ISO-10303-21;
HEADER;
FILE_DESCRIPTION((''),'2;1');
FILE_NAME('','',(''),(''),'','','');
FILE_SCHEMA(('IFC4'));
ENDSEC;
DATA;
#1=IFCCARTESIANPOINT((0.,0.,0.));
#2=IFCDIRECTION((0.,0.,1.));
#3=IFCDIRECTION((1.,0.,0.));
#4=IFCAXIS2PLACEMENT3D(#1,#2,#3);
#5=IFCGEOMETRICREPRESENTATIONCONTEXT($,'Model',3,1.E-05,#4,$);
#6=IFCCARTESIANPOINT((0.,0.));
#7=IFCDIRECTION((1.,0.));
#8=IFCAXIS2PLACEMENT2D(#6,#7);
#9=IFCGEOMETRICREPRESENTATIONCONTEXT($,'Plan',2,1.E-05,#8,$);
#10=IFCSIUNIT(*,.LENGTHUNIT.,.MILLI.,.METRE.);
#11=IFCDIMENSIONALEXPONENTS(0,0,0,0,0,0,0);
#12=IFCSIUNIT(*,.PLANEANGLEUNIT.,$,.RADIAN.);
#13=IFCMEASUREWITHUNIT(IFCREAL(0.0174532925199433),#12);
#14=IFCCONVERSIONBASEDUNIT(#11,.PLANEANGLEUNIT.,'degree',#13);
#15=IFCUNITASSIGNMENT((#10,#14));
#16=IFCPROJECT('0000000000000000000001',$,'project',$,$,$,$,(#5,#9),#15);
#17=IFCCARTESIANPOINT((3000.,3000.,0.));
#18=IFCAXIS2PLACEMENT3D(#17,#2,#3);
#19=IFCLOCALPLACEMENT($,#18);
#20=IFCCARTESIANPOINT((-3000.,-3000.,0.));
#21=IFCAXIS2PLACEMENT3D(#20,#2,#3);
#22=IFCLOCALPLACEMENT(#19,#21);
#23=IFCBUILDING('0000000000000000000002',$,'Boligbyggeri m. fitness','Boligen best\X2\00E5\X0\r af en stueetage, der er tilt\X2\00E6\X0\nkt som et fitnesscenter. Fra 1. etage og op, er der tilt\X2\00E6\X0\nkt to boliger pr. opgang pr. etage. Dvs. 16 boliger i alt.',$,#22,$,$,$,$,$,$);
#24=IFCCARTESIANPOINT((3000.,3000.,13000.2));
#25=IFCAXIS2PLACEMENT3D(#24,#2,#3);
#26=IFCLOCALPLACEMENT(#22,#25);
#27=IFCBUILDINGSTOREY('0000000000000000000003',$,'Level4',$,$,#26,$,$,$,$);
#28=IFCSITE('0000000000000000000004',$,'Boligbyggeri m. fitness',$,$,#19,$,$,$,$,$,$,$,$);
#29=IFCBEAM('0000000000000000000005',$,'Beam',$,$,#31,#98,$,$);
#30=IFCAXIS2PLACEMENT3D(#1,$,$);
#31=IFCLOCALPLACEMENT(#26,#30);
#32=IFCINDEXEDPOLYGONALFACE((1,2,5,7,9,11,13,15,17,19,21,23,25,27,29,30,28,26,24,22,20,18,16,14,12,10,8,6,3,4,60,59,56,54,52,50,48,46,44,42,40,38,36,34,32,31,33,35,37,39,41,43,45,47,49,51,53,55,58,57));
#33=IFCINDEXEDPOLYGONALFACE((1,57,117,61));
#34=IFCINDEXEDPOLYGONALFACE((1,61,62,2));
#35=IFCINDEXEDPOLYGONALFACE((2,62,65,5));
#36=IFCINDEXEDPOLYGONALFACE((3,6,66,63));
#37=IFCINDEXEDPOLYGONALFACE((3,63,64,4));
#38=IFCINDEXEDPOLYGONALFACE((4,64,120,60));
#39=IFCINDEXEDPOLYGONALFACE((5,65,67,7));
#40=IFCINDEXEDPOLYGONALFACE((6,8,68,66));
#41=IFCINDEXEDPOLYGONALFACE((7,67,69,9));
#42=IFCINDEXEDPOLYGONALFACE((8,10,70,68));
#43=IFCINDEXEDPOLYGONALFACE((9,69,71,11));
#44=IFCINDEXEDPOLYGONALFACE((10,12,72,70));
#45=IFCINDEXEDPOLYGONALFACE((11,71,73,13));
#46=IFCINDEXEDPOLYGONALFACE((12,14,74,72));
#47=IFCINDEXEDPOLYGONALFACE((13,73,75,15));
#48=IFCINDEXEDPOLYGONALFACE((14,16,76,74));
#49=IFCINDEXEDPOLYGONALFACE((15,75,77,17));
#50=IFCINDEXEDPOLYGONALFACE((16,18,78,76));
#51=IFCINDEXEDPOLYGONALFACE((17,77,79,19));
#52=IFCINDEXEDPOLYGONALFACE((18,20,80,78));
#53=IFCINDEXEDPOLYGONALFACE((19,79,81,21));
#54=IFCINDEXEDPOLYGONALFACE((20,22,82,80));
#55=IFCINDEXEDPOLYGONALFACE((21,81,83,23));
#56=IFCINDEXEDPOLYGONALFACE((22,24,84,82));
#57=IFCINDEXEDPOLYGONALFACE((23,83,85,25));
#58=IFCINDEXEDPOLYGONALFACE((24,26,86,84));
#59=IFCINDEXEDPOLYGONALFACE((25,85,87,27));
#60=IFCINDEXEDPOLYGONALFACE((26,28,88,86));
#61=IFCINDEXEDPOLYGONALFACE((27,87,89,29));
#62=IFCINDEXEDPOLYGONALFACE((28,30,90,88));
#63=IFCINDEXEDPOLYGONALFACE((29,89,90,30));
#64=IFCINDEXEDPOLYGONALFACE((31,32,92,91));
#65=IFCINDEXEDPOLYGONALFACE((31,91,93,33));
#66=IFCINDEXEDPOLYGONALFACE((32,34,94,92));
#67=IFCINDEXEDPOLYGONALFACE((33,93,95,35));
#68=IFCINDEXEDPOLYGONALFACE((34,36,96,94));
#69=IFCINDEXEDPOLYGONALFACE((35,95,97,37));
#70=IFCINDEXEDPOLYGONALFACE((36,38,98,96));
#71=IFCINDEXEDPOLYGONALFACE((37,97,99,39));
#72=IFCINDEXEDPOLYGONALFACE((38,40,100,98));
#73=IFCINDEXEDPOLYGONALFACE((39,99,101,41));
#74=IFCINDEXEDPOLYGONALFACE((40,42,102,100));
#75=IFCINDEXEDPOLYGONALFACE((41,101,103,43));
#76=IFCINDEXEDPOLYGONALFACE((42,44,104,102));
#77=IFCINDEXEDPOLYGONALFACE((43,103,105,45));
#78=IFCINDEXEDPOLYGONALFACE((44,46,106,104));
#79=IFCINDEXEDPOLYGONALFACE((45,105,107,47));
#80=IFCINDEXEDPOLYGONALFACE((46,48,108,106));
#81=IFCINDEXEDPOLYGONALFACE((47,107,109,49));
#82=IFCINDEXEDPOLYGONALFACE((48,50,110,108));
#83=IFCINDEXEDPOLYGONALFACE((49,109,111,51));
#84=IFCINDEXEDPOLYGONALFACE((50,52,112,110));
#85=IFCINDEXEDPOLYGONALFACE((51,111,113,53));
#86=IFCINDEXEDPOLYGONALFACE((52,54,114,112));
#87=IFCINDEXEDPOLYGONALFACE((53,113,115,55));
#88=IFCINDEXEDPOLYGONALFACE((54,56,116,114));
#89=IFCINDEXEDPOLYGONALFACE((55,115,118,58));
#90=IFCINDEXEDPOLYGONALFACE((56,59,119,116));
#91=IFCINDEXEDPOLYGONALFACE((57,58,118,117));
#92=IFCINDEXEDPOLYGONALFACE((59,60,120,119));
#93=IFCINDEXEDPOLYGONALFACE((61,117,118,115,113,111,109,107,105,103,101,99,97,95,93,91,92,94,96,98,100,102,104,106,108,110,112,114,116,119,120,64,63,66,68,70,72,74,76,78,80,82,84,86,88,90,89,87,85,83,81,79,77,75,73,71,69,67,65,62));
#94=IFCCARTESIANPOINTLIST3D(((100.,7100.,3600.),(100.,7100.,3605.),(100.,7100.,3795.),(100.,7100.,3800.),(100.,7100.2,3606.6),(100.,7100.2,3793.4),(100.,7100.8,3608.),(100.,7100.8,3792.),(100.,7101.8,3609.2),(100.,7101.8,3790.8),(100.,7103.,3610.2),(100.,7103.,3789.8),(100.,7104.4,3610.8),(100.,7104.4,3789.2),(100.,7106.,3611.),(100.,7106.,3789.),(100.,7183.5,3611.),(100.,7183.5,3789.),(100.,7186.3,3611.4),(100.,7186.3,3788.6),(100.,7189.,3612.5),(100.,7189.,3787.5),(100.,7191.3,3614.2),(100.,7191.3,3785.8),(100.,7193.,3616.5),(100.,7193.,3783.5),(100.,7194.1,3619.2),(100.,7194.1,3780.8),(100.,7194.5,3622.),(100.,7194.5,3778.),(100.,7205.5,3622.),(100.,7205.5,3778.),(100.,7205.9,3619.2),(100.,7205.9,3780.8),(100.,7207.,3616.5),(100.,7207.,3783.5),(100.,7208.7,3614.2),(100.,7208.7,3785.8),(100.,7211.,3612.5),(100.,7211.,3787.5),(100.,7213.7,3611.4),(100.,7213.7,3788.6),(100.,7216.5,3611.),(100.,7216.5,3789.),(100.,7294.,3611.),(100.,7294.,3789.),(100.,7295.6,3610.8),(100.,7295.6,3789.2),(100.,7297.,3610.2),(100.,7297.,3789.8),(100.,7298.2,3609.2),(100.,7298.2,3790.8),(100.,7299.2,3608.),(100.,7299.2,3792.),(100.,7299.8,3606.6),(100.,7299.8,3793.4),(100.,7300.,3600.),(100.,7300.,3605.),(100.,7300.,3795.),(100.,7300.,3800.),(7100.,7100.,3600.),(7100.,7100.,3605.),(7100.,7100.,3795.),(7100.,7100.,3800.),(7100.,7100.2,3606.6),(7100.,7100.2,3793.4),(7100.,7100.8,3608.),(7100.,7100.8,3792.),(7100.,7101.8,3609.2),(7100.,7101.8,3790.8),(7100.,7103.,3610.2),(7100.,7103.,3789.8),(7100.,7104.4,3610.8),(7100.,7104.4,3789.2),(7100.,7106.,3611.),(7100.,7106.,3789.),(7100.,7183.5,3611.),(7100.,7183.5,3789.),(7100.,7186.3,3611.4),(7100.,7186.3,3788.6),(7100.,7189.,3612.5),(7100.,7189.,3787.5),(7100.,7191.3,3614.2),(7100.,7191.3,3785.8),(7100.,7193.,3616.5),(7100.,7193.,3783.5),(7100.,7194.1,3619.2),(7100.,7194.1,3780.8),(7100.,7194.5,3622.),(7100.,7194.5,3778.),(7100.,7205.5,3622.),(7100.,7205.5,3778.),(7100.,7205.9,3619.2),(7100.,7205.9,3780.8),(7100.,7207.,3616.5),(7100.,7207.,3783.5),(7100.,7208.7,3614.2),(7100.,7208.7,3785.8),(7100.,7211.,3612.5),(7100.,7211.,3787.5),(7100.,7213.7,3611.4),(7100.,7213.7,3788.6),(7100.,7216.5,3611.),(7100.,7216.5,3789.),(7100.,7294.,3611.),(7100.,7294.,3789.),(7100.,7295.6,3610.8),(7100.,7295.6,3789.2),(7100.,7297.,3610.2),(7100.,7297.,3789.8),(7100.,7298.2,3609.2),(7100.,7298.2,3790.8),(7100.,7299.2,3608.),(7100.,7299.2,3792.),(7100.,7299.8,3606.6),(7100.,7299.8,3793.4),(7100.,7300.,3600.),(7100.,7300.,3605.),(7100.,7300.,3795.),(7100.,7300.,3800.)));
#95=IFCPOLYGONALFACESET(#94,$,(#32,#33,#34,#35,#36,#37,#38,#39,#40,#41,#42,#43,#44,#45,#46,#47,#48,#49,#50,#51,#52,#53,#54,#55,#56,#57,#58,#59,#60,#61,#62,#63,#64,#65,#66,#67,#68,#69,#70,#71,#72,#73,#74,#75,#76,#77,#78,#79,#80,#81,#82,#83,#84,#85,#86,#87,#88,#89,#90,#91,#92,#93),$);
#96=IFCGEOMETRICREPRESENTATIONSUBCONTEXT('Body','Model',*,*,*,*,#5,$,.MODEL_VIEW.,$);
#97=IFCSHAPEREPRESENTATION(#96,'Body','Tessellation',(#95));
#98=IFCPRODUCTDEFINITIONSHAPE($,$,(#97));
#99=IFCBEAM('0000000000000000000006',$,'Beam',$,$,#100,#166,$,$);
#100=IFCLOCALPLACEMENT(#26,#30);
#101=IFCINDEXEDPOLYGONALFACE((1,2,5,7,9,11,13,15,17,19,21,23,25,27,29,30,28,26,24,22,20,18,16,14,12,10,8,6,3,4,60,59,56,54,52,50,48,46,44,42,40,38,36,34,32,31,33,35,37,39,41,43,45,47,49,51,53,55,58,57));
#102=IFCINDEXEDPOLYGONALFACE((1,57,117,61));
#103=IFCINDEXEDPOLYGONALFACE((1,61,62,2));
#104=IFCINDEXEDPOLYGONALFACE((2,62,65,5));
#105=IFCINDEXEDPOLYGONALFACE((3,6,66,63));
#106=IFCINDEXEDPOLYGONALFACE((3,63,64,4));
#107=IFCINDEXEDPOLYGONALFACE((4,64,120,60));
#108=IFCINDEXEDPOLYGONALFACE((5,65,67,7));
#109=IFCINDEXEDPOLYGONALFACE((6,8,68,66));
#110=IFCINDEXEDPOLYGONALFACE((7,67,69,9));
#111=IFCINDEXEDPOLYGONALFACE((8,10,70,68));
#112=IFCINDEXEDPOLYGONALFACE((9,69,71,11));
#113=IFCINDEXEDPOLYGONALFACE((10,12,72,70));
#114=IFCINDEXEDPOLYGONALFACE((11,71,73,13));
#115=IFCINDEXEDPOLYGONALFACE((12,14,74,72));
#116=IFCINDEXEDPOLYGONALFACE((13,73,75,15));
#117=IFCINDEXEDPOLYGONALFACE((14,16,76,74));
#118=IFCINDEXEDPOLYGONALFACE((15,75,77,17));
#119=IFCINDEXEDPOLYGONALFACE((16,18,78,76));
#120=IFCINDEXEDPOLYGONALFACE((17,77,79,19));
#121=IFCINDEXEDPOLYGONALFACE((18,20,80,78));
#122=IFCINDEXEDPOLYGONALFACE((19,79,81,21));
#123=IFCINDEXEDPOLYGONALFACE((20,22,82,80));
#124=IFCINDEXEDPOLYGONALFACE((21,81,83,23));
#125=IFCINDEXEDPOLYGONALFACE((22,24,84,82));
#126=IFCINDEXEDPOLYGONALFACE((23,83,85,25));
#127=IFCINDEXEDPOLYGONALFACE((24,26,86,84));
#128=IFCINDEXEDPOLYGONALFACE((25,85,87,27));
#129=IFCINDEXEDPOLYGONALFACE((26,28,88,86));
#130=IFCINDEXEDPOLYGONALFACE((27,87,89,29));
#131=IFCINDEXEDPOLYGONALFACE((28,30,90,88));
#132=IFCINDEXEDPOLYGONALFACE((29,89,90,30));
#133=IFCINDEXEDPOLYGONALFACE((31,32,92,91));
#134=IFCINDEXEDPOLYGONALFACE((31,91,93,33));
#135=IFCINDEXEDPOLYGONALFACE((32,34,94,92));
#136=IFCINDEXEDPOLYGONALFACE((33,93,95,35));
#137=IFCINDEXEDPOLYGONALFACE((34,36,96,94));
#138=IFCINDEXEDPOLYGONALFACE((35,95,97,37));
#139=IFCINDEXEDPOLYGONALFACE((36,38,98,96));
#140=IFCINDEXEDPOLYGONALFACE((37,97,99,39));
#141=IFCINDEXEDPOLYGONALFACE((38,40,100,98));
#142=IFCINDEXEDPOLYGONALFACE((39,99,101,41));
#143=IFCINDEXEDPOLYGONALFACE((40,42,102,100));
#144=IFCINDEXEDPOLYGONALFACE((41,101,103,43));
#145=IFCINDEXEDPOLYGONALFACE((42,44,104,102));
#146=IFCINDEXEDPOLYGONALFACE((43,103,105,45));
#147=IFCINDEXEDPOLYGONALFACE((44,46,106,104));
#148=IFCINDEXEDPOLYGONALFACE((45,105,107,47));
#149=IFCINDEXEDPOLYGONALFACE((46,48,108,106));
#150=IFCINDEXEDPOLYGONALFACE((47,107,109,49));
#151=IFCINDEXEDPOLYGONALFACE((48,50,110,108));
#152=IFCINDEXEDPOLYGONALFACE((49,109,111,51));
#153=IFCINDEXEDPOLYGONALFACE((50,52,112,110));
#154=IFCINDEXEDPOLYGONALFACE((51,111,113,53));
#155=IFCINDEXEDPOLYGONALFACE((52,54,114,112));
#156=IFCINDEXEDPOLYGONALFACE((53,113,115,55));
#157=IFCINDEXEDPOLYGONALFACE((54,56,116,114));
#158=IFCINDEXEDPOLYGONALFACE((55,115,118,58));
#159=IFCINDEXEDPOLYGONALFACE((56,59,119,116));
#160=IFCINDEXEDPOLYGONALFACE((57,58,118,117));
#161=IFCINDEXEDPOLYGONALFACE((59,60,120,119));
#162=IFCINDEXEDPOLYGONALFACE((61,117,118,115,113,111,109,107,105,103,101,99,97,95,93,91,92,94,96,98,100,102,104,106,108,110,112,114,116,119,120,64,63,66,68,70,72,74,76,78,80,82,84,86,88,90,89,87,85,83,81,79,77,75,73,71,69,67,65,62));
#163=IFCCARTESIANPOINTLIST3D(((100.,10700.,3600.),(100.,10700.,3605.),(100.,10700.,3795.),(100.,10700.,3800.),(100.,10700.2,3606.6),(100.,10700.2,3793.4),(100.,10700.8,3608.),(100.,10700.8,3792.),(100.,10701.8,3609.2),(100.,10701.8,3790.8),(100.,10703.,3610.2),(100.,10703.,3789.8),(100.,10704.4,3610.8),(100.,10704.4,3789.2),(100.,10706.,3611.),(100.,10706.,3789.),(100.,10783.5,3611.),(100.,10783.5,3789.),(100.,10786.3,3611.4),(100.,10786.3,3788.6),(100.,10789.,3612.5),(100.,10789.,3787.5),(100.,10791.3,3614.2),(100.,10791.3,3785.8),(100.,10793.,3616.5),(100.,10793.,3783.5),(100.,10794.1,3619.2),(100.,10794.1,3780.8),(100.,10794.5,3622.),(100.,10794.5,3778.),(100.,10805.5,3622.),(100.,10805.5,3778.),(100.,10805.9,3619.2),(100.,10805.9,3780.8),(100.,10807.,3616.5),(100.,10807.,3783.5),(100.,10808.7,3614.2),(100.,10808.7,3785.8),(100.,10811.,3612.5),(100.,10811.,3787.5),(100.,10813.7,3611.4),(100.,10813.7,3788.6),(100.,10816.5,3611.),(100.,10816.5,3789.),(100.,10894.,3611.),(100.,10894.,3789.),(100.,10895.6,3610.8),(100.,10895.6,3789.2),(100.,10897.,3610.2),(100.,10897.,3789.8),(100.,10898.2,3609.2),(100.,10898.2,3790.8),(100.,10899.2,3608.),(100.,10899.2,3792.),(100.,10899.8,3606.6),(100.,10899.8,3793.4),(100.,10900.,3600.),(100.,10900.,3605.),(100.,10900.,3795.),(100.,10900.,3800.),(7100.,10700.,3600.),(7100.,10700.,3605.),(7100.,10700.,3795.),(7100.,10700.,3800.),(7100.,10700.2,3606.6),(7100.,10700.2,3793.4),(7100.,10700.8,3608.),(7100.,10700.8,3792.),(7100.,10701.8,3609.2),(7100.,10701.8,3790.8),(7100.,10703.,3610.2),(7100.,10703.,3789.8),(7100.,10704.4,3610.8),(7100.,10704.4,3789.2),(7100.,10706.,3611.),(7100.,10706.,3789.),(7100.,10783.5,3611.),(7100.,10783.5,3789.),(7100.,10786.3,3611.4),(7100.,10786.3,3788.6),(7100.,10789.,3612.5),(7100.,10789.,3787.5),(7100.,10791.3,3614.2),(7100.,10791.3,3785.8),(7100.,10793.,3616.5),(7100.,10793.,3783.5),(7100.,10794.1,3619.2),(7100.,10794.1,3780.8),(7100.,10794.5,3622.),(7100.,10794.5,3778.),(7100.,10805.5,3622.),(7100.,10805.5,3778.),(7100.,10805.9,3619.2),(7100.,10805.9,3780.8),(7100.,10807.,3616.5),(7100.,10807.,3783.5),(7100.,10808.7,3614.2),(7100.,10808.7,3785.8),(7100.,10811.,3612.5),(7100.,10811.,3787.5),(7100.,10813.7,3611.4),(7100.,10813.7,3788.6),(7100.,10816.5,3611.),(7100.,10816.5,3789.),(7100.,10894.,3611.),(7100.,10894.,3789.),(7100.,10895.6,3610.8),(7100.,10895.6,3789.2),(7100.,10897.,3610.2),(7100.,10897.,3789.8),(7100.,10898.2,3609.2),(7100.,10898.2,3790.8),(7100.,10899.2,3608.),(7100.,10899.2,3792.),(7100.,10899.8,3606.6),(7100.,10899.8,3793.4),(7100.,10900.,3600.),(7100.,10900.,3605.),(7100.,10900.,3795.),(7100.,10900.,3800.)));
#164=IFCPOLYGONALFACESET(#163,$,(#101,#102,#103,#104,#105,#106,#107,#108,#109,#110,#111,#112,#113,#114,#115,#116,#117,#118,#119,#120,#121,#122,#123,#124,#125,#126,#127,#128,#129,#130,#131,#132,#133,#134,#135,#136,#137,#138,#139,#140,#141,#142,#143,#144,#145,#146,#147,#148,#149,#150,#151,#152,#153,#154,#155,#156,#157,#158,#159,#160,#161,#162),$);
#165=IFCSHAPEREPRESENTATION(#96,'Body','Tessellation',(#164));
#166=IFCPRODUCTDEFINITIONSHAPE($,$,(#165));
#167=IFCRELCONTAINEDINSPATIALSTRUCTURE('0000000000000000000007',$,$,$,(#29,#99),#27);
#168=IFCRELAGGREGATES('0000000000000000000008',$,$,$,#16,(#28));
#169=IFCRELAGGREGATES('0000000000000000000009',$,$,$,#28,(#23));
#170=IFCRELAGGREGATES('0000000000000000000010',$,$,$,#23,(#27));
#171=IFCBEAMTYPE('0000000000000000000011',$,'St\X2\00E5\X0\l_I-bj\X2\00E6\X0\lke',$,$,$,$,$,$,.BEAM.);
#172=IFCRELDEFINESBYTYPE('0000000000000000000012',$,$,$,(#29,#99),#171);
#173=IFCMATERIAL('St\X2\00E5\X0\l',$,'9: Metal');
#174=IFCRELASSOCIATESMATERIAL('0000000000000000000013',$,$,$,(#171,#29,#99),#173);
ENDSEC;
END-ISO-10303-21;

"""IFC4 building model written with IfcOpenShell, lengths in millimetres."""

from ifc_helpers import new_model, entity, si_unit, converted_unit, frame, origin_with_axes, origin_2d_with_axis, place, context, subcontext, project, spatial, i_section, extrude, material, material_profile, profile_set, profile_usage, type_object, element, save


model = new_model("IFC4")

# Units and contexts
model_context = context("Model", 3, precision=1e-05, world=origin_with_axes())
plan_context = context("Plan", 2, precision=1e-05, world=origin_2d_with_axis())
body_context = subcontext(model_context, "Body", "Model", "MODEL_VIEW")
ifc_project = project(units=[si_unit("LENGTHUNIT", "METRE", prefix="MILLI"), converted_unit("PLANEANGLEUNIT", "degree", entity("IfcReal", 0.0174532925199433), si_unit("PLANEANGLEUNIT", "RADIAN"), dimensions=[0, 0, 0, 0, 0, 0, 0])], contexts=[model_context, plan_context])

# Site, building, storey
site_placement = place(None, frame((3000.0, 3000.0, 0.0), z_axis=(0.0, 0.0, 1.0), x_axis=(1.0, 0.0, 0.0)))
site = spatial("IfcSite", under=ifc_project, at=site_placement, Name="Boligbyggeri m. fitness")
building_placement = place(site_placement, frame((-3000.0, -3000.0, 0.0), z_axis=(0.0, 0.0, 1.0), x_axis=(1.0, 0.0, 0.0)))
building = spatial("IfcBuilding", under=site, at=building_placement, Name="Boligbyggeri m. fitness", Description="Boligen består af en stueetage, der er tiltænkt som et fitnesscenter. Fra 1. etage og op, er der tiltænkt to boliger pr. opgang pr. etage. Dvs. 16 boliger i alt.")
storey_placement = place(building_placement, frame((3000.0, 3000.0, 13000.2), z_axis=(0.0, 0.0, 1.0), x_axis=(1.0, 0.0, 0.0)))
storey = spatial("IfcBuildingStorey", under=building, at=storey_placement, Name="Level4")

# Beams
ifc_material_1 = material(Name="Stål", Category="9: Metal")
ifc_material_profile_1 = material_profile(ifc_material_1, i_section(OverallWidth=200.0, OverallDepth=200.0, WebThickness=11.0, FlangeThickness=11.0, FilletRadius=11.0, FlangeEdgeRadius=6.0), Name="Stål", Category="9: Metal")
ifc_profile_set_1 = profile_set([ifc_material_profile_1], Name="NY_I-Profil")
beam_type = type_object("IfcBeamType", Name="Stål_I-bjælke", PredefinedType="BEAM", material=ifc_profile_set_1)
ifc_profile_usage_1 = profile_usage(ifc_profile_set_1, cardinal=7)
beam_1_placement = place(storey_placement, frame((100.0, 7300.0, 3800.0), z_axis=(1.0, 0.0, 0.0), x_axis=(0.0, 1.0, 0.0)))
element("IfcBeam", 1, at=beam_1_placement, inside=storey, type_object=beam_type, material=ifc_profile_usage_1, Name="Beam", context=body_context, shape_type="SweptSolid", body=[
    extrude(i_section(OverallWidth=200.0, OverallDepth=200.0, WebThickness=11.0, FlangeThickness=11.0, FilletRadius=11.0, FlangeEdgeRadius=6.0), frame((-100.0, -100.0, 0.0), z_axis=(0.0, 0.0, 1.0), x_axis=(1.0, 0.0, 0.0)), (0.0, 0.0, 1.0), 7000.0),
])
ifc_profile_usage_2 = profile_usage(ifc_profile_set_1, cardinal=7)
beam_2_placement = place(storey_placement, frame((100.0, 10900.0, 3800.0), z_axis=(1.0, 0.0, 0.0), x_axis=(0.0, 1.0, 0.0)))
element("IfcBeam", 2, at=beam_2_placement, inside=storey, type_object=beam_type, material=ifc_profile_usage_2, Name="Beam", context=body_context, shape_type="SweptSolid", body=[
    extrude(i_section(OverallWidth=200.0, OverallDepth=200.0, WebThickness=11.0, FlangeThickness=11.0, FilletRadius=11.0, FlangeEdgeRadius=6.0), frame((-100.0, -100.0, 0.0), z_axis=(0.0, 0.0, 1.0), x_axis=(1.0, 0.0, 0.0)), (0.0, 0.0, 1.0), 7000.0),
])

save(model, "model.ifc")
